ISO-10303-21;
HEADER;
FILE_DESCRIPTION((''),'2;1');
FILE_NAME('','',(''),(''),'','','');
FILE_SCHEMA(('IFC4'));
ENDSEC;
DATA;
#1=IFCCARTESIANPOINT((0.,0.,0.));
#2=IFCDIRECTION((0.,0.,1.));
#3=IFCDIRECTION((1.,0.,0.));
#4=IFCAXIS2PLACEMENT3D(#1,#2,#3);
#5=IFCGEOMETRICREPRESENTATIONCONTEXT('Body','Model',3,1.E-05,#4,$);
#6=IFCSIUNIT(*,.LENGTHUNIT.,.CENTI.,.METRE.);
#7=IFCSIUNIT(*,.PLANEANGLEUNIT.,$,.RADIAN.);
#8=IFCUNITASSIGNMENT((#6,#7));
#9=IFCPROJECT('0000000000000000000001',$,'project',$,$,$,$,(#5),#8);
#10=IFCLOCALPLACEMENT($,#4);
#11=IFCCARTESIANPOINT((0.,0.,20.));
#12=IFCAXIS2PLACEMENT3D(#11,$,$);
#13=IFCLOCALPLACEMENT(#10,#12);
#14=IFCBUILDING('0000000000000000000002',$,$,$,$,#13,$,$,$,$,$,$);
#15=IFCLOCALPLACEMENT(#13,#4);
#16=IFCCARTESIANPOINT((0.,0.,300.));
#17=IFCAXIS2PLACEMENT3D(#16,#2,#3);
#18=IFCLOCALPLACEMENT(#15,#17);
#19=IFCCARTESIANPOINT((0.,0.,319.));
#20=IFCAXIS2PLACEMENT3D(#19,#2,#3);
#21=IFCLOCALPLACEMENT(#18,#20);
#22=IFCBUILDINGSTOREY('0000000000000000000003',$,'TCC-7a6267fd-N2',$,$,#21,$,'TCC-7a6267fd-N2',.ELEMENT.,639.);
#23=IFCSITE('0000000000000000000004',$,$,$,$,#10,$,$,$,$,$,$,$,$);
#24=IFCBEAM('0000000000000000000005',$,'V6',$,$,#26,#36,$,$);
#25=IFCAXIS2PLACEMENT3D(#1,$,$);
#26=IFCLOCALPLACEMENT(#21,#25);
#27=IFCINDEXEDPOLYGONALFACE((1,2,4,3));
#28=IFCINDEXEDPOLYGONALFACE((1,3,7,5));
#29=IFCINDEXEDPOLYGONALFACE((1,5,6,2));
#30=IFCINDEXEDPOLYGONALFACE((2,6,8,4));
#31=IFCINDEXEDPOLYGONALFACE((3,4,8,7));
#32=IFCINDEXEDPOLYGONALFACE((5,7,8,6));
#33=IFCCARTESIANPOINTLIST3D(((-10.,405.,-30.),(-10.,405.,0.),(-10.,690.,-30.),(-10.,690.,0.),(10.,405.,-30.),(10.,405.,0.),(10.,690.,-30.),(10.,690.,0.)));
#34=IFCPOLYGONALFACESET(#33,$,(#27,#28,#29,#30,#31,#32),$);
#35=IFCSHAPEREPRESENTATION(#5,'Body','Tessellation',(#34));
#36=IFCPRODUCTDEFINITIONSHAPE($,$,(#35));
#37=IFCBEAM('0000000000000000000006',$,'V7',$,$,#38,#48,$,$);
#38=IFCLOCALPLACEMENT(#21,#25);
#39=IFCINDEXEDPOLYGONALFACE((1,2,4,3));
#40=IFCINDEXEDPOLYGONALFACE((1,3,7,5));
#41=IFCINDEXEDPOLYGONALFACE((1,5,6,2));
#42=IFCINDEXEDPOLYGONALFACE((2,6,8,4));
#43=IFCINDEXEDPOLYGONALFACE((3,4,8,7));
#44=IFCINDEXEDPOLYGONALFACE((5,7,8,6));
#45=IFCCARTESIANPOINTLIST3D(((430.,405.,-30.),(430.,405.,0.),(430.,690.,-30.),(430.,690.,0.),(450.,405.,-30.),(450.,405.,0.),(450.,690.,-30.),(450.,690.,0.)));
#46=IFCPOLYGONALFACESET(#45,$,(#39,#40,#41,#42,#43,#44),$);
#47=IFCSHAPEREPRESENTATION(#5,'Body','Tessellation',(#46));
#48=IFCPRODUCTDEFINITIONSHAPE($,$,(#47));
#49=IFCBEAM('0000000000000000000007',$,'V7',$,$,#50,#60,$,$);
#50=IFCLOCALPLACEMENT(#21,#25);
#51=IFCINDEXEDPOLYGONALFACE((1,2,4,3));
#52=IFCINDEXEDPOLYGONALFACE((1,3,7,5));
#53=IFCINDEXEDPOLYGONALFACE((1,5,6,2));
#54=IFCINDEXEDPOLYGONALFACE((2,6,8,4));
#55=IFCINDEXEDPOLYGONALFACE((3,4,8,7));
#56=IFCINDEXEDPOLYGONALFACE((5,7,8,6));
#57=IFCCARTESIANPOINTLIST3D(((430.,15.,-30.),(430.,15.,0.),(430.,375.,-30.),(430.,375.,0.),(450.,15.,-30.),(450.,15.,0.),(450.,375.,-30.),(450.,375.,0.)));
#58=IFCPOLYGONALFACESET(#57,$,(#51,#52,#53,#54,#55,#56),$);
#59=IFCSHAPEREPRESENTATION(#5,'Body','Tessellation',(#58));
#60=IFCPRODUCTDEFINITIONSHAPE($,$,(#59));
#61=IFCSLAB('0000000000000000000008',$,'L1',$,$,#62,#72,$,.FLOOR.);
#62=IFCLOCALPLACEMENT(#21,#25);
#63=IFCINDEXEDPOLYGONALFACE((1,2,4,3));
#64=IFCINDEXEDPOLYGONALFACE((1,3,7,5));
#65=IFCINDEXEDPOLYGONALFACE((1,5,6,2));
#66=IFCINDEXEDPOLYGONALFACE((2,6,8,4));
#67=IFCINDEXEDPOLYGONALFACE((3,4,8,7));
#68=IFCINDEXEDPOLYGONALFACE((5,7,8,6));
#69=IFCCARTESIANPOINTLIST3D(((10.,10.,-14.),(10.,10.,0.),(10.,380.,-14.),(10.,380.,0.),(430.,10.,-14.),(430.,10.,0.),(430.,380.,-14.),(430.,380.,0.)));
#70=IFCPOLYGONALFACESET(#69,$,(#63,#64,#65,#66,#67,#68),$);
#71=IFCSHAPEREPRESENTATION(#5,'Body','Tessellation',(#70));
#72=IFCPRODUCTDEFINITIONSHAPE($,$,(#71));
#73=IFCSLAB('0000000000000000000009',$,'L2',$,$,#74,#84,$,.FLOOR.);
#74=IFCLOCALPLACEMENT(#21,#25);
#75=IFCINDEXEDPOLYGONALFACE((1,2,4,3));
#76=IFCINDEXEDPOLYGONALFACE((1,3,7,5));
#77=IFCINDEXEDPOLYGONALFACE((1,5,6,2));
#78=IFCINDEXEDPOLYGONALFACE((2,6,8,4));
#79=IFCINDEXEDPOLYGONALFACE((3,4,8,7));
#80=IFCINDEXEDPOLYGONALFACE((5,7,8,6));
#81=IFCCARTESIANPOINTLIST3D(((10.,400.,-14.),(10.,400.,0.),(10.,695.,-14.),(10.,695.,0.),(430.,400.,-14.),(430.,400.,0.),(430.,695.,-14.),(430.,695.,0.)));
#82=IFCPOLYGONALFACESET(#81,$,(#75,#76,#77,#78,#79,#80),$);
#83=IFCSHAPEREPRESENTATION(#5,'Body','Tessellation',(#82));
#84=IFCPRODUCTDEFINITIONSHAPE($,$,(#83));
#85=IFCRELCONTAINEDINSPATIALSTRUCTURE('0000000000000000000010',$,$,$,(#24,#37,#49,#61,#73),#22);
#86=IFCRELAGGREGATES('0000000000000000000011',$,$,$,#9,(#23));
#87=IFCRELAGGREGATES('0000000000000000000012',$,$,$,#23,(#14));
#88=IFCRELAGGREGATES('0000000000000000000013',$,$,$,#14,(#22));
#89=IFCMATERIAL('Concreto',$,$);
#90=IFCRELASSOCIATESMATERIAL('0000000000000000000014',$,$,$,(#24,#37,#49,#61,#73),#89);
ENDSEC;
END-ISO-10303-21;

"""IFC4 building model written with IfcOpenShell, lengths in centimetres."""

from ifc_helpers import new_model, si_unit, frame, origin_with_axes, origin_2d_with_axis, place, context, project, spatial, polyline, rectangle, outline, extrude, material, element, save


model = new_model("IFC4")

# Units and contexts
model_context = context("Model", 3, precision=1e-05, world=origin_with_axes(), identifier="Body")
ifc_project = project(units=[si_unit("LENGTHUNIT", "METRE", prefix="CENTI"), si_unit("PLANEANGLEUNIT", "RADIAN")], contexts=[model_context])

# Site, building, storey
site_placement = place(None, origin_with_axes())
site = spatial("IfcSite", under=ifc_project, at=site_placement)
building_placement = place(site_placement, frame((0.0, 0.0, 20.0)))
building = spatial("IfcBuilding", under=site, at=building_placement)
placement_1 = place(building_placement, origin_with_axes())
placement_2 = place(placement_1, frame((0.0, 0.0, 300.0), z_axis=(0.0, 0.0, 1.0), x_axis=(1.0, 0.0, 0.0)))
storey_placement = place(placement_2, frame((0.0, 0.0, 319.0), z_axis=(0.0, 0.0, 1.0), x_axis=(1.0, 0.0, 0.0)))
storey = spatial("IfcBuildingStorey", under=building, at=storey_placement, Name="TCC-7a6267fd-N2", LongName="TCC-7a6267fd-N2", CompositionType="ELEMENT", Elevation=639.0)

# Shared definitions
ifc_material = material(Name="Concreto")

# Beams
beam_1_placement = place(storey_placement, frame((0.0, 547.5, 0.0), z_axis=(0.0, 0.0, 1.0), x_axis=(1.0, 0.0, 0.0)))
element("IfcBeam", 1, at=beam_1_placement, inside=storey, material=ifc_material, Name="V6", context=model_context, shape_type="SolidModel", body=[
    extrude(rectangle(XDim=20.0, YDim=30.0, at=origin_2d_with_axis()), frame((0.0, 142.5, -15.0), z_axis=(0.0, -1.0, 0.0), x_axis=(-1.0, 0.0, 0.0)), (0.0, 0.0, 1.0), 285.0),
])
beam_2_placement = place(storey_placement, frame((440.0, 547.5, 0.0), z_axis=(0.0, 0.0, 1.0), x_axis=(1.0, 0.0, 0.0)))
element("IfcBeam", 2, at=beam_2_placement, inside=storey, material=ifc_material, Name="V7", context=model_context, shape_type="SolidModel", body=[
    extrude(rectangle(XDim=20.0, YDim=30.0, at=origin_2d_with_axis()), frame((0.0, 142.5, -15.0), z_axis=(0.0, -1.0, 0.0), x_axis=(1.0, 0.0, 0.0)), (0.0, 0.0, 1.0), 285.0),
])
beam_3_placement = place(storey_placement, frame((440.0, 195.0, 0.0), z_axis=(0.0, 0.0, 1.0), x_axis=(1.0, 0.0, 0.0)))
element("IfcBeam", 3, at=beam_3_placement, inside=storey, material=ifc_material, Name="V7", context=model_context, shape_type="SolidModel", body=[
    extrude(rectangle(XDim=20.0, YDim=30.0, at=origin_2d_with_axis()), frame((0.0, 180.0, -15.0), z_axis=(0.0, -1.0, 0.0), x_axis=(1.0, 0.0, 0.0)), (0.0, 0.0, 1.0), 360.0),
])

# Slabs
slab_1_placement = place(storey_placement, frame((220.0, 195.0, 0.0), z_axis=(0.0, 0.0, 1.0), x_axis=(1.0, 0.0, 0.0)))
element("IfcSlab", 4, at=slab_1_placement, inside=storey, material=ifc_material, Name="L1", PredefinedType="FLOOR", context=model_context, shape_type="SolidModel", body=[
    extrude(outline(polyline([(210.0, 185.0), (-210.0, 185.0), (-210.0, -185.0), (210.0, -185.0), (210.0, 185.0), (210.0, 185.0)])), frame((0.0, 0.0, -14.0), z_axis=(0.0, 0.0, 1.0), x_axis=(1.0, 0.0, 0.0)), (0.0, 0.0, 1.0), 14.0),
])
slab_2_placement = place(storey_placement, frame((220.0, 547.5, 0.0), z_axis=(0.0, 0.0, 1.0), x_axis=(1.0, 0.0, 0.0)))
element("IfcSlab", 5, at=slab_2_placement, inside=storey, material=ifc_material, Name="L2", PredefinedType="FLOOR", context=model_context, shape_type="SolidModel", body=[
    extrude(outline(polyline([(210.0, 147.5), (-210.0, 147.5), (-210.0, -147.5), (210.0, -147.5), (210.0, 147.5), (210.0, 147.5)])), frame((0.0, 0.0, -14.0), z_axis=(0.0, 0.0, 1.0), x_axis=(1.0, 0.0, 0.0)), (0.0, 0.0, 1.0), 14.0),
])

save(model, "model.ifc")
